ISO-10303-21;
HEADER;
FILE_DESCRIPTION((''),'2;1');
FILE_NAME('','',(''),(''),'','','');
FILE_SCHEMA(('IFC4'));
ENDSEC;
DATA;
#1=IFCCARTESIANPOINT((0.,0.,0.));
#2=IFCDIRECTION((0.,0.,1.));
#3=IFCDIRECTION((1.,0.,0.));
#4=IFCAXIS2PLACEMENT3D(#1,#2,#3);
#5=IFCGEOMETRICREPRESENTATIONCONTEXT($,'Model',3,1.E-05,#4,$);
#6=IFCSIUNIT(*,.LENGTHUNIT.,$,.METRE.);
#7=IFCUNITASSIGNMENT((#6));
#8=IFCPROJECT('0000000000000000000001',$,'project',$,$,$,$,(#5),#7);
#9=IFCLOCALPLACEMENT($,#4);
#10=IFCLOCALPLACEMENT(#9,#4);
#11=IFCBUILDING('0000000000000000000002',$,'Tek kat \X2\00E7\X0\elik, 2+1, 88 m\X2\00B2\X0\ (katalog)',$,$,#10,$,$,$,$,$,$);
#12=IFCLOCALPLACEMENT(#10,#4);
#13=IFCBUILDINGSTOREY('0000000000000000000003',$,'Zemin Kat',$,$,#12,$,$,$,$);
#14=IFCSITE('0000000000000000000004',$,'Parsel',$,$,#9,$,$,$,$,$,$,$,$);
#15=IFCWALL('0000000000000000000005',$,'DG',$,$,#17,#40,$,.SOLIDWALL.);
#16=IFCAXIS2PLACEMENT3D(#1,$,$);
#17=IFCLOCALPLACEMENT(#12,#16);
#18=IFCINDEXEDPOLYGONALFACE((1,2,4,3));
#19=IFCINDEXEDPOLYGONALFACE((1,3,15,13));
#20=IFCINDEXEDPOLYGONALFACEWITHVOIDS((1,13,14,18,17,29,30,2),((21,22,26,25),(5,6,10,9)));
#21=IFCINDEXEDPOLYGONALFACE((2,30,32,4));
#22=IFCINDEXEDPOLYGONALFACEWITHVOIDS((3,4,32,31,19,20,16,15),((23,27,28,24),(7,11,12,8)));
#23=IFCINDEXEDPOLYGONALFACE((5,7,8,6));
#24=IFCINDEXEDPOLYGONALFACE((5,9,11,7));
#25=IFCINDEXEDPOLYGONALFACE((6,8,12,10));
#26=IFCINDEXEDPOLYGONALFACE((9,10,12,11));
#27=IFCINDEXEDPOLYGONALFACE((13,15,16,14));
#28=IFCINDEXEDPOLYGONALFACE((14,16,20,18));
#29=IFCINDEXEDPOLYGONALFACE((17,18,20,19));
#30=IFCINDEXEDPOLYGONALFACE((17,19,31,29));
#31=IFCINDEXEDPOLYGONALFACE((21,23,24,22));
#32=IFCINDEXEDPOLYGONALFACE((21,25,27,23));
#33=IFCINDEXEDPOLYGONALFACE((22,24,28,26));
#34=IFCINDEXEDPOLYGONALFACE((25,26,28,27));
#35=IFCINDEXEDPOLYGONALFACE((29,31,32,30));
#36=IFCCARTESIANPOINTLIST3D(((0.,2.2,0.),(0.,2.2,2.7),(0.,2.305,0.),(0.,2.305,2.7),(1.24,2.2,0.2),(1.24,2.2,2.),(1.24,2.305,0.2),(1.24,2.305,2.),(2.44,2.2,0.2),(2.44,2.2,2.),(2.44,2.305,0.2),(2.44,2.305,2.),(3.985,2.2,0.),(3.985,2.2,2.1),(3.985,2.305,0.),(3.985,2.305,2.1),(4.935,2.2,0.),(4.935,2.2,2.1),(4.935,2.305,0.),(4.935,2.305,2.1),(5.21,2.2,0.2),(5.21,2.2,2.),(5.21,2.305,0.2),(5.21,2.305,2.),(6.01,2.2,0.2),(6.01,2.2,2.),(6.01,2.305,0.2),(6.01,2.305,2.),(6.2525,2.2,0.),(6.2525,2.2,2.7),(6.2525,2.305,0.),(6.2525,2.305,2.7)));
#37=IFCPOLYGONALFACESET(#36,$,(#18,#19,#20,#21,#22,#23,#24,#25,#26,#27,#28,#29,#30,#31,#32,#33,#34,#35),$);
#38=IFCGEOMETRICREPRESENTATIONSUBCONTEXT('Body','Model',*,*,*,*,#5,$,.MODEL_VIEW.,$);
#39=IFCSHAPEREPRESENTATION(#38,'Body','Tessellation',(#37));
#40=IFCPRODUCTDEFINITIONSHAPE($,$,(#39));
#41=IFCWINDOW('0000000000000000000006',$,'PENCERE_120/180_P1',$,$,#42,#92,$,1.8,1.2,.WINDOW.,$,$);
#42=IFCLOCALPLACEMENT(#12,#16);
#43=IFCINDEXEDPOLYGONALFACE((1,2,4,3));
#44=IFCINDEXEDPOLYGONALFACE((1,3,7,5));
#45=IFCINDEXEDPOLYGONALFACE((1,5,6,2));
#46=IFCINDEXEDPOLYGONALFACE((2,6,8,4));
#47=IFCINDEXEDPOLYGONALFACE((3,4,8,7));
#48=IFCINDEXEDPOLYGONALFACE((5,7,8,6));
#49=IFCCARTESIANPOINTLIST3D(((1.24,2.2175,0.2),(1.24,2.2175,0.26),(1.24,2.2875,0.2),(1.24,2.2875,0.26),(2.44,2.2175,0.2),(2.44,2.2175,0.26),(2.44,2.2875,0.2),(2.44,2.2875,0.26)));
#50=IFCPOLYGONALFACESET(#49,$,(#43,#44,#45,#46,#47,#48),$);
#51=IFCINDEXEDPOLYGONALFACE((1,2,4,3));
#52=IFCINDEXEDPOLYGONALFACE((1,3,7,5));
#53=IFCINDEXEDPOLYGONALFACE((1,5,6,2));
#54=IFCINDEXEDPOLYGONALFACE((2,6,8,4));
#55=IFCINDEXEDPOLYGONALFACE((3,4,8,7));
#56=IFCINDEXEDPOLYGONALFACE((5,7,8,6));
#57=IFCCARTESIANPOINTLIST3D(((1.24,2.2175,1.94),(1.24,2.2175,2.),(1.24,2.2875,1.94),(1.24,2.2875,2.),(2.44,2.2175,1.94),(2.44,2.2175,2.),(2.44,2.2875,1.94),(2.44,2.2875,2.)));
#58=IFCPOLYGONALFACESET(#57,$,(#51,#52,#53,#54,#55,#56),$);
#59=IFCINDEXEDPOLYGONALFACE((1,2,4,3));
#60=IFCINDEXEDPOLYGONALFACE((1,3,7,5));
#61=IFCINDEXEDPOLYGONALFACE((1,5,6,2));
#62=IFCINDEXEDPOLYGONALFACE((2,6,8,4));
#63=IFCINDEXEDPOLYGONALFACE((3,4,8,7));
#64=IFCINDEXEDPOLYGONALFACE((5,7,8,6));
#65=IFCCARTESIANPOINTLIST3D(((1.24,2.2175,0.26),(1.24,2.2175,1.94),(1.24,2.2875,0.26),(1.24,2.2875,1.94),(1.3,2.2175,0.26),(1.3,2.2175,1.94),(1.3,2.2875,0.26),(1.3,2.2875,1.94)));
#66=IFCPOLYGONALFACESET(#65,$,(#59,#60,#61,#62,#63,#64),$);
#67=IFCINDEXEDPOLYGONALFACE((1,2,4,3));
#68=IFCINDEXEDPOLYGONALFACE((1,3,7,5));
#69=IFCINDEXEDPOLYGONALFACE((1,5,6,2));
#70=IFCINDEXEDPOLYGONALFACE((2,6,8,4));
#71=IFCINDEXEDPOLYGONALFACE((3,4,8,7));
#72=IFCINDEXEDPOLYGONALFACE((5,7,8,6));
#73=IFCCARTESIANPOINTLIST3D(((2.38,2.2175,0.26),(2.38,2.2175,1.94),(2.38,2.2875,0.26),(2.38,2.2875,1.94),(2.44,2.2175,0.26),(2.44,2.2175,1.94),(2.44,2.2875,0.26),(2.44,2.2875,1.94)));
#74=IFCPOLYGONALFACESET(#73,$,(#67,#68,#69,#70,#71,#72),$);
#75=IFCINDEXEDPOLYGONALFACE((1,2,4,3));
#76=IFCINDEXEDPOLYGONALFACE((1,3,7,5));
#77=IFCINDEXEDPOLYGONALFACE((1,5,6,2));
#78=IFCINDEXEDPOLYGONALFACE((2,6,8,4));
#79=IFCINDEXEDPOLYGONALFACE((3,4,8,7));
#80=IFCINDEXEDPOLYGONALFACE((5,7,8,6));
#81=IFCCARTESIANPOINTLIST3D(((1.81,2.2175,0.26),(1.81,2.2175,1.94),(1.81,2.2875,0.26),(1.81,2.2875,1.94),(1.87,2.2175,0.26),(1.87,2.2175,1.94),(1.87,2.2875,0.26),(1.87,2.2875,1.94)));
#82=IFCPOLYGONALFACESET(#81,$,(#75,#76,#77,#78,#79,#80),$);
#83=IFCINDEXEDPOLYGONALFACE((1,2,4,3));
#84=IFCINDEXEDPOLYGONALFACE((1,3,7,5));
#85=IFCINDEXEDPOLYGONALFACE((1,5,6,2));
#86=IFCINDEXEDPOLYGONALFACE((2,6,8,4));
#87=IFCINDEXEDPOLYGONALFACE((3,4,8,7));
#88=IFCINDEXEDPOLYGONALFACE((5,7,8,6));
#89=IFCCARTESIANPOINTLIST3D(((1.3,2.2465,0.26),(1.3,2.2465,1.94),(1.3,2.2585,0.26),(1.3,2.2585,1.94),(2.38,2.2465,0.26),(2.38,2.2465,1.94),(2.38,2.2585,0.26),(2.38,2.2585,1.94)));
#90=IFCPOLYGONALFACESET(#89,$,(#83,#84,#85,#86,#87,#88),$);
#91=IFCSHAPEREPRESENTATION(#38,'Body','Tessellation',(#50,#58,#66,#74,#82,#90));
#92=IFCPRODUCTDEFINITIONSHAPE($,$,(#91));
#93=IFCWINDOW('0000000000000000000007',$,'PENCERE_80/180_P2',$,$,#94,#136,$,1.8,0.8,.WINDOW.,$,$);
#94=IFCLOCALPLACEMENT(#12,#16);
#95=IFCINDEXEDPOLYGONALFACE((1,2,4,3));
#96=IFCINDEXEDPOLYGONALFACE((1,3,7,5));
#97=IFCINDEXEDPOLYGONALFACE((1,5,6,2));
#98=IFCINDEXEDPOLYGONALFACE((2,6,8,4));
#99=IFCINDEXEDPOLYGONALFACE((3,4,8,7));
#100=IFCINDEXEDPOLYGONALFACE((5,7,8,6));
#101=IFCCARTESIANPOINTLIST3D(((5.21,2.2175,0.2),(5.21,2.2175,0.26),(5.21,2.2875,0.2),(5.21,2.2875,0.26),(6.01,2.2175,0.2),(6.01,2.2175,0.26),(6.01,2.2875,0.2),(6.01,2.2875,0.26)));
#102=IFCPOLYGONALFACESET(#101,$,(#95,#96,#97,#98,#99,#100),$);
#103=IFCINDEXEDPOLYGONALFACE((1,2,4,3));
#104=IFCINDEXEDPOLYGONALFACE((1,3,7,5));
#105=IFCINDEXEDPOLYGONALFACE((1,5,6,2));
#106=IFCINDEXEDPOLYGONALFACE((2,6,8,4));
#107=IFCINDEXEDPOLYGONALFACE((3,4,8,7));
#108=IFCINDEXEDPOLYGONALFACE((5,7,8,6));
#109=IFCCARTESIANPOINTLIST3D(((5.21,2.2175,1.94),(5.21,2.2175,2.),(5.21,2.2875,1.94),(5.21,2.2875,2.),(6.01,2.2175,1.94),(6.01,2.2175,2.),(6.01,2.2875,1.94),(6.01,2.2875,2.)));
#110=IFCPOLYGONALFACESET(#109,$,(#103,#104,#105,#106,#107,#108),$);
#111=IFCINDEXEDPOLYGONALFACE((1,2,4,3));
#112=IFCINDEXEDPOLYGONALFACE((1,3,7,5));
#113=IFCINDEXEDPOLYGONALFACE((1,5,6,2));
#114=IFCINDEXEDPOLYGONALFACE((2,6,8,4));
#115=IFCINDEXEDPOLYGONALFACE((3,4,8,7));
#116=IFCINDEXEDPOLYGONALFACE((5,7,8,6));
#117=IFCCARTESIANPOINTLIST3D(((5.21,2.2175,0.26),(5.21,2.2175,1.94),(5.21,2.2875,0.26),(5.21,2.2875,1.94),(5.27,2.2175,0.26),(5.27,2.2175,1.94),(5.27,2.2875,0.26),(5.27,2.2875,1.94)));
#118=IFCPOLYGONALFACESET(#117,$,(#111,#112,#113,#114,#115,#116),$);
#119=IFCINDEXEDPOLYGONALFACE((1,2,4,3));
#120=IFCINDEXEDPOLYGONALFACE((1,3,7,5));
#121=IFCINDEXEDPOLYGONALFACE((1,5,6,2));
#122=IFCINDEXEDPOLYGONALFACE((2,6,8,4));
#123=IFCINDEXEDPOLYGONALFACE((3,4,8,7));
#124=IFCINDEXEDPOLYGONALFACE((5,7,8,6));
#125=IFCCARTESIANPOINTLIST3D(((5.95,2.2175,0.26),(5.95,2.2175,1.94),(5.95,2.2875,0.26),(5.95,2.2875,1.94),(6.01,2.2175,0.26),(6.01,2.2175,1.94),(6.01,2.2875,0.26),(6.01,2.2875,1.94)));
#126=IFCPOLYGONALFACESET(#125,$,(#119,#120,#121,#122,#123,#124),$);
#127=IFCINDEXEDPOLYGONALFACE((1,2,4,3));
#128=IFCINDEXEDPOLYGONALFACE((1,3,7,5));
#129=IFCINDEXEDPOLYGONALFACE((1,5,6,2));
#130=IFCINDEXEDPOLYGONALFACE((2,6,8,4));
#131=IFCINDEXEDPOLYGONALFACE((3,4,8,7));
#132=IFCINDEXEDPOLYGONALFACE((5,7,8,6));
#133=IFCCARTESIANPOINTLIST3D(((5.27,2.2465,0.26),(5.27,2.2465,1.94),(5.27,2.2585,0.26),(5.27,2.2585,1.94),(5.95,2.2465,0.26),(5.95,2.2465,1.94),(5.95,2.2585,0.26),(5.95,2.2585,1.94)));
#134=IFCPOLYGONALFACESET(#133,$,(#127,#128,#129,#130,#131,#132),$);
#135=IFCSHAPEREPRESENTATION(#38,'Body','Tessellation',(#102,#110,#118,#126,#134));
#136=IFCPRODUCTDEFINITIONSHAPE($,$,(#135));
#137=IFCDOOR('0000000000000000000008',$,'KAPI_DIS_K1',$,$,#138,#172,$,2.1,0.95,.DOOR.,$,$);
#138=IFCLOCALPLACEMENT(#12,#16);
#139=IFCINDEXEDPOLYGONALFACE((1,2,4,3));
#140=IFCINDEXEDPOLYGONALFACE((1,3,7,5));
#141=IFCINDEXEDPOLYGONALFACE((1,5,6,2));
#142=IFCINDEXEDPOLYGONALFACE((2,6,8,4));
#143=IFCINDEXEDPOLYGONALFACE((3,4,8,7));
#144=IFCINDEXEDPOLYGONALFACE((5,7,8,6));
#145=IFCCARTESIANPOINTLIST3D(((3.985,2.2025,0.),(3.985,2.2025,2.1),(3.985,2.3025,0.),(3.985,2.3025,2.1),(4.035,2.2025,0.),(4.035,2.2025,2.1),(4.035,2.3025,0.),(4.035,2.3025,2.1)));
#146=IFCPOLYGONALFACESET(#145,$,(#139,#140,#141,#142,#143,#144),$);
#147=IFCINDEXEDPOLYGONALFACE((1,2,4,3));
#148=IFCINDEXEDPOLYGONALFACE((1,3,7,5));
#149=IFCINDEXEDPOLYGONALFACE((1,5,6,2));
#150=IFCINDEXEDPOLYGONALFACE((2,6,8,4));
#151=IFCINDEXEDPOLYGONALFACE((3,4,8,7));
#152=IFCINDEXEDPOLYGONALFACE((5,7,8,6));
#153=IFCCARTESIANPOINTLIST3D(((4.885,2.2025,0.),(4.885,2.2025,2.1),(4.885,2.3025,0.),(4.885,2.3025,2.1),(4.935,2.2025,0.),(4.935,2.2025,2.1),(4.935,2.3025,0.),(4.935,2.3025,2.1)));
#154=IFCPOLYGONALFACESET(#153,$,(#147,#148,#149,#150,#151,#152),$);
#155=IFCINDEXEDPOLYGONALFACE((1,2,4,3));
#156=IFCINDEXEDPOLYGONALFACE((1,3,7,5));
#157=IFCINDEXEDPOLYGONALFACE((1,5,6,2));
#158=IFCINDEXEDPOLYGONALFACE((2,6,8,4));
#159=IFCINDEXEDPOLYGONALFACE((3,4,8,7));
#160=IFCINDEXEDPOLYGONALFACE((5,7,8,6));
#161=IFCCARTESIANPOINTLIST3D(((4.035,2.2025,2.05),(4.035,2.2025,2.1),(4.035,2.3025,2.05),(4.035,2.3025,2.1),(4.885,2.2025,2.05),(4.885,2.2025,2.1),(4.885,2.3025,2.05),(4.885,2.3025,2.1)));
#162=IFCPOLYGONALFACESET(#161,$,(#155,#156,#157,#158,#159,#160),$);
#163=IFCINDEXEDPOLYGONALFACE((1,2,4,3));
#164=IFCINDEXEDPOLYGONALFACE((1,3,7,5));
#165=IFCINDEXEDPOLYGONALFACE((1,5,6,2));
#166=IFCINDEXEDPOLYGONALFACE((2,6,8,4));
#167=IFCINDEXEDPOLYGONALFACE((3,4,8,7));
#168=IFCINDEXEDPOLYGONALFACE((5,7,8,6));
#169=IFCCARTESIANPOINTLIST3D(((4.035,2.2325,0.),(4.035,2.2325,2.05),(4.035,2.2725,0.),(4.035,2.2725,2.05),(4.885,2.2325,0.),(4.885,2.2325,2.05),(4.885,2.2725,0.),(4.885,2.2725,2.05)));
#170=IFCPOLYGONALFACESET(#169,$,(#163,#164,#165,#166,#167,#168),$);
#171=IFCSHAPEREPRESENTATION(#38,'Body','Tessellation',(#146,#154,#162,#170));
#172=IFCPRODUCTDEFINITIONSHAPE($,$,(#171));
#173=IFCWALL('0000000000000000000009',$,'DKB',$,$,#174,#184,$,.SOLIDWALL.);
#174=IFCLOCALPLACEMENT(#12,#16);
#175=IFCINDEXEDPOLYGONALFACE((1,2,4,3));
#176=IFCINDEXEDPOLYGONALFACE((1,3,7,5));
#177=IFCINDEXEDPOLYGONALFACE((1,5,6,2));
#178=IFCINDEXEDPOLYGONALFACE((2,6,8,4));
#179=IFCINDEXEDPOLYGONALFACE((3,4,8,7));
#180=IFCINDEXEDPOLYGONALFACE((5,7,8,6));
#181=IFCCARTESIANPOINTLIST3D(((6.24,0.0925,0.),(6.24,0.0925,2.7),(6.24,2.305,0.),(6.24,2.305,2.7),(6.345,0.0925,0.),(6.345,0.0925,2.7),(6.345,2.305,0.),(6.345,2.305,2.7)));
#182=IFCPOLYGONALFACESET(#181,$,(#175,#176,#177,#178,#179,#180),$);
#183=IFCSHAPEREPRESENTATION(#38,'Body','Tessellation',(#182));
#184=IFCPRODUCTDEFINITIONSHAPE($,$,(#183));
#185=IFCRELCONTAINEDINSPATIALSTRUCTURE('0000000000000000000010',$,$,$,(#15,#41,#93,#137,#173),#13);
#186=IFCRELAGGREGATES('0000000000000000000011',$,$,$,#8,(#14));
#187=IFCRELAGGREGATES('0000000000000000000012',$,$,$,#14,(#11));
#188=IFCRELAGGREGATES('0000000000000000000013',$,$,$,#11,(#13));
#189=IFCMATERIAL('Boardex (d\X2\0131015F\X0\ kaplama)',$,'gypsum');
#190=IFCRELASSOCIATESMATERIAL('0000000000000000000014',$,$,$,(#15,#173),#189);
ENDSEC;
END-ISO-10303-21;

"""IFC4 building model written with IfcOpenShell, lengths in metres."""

from ifc_helpers import new_model, si_unit, frame, origin_with_axes, place, context, subcontext, project, spatial, line, indexed_curve, outline, extrude, material, element, fill, save


model = new_model("IFC4")

# Units and contexts
model_context = context("Model", 3, precision=1e-05, world=origin_with_axes())
body_context = subcontext(model_context, "Body", "Model", "MODEL_VIEW")
ifc_project = project(units=[si_unit("LENGTHUNIT", "METRE")], contexts=[model_context])

# Site, building, storey
site_placement = place(None, origin_with_axes())
site = spatial("IfcSite", under=ifc_project, at=site_placement, Name="Parsel")
building_placement = place(site_placement, origin_with_axes())
building = spatial("IfcBuilding", under=site, at=building_placement, Name="Tek kat çelik, 2+1, 88 m² (katalog)")
storey_placement = place(building_placement, origin_with_axes())
storey = spatial("IfcBuildingStorey", under=building, at=storey_placement, Name="Zemin Kat")

# Shared definitions
ifc_material = material(Name="Boardex (dış kaplama)", Category="gypsum")

# Wall, openings, windows, door
wall_1_placement = place(storey_placement, origin_with_axes())
wall_1 = element("IfcWall", 1, at=wall_1_placement, inside=storey, material=ifc_material, Name="DG", PredefinedType="SOLIDWALL", context=body_context, shape_type="SweptSolid", body=[
    extrude(outline(indexed_curve([(0.0, 0.0), (6.2525, 0.0), (6.2525, 0.105), (0.0, 0.105)], segments=[line(1, 2, 3, 4, 1)])), frame((0.0, 2.2, 0.0), z_axis=(0.0, 0.0, 1.0), x_axis=(1.0, 0.0, 0.0)), (0.0, 0.0, 1.0), 2.7),
])
opening_1_placement = place(wall_1_placement, origin_with_axes())
opening_1 = element("IfcOpeningElement", 2, at=opening_1_placement, cuts=wall_1, PredefinedType="OPENING", context=body_context, shape_type="SweptSolid", body=[
    extrude(outline(indexed_curve([(0.0, 0.0), (1.2, 0.0), (1.2, 0.145), (0.0, 0.145)], segments=[line(1, 2, 3, 4, 1)])), frame((1.24, 2.18, 0.2), z_axis=(0.0, 0.0, 1.0), x_axis=(1.0, 0.0, 0.0)), (0.0, 0.0, 1.0), 1.8),
])
opening_2_placement = place(wall_1_placement, origin_with_axes())
opening_2 = element("IfcOpeningElement", 3, at=opening_2_placement, cuts=wall_1, PredefinedType="OPENING", context=body_context, shape_type="SweptSolid", body=[
    extrude(outline(indexed_curve([(0.0, 0.0), (0.8, 0.0), (0.8, 0.145), (0.0, 0.145)], segments=[line(1, 2, 3, 4, 1)])), frame((5.21, 2.18, 0.2), z_axis=(0.0, 0.0, 1.0), x_axis=(1.0, 0.0, 0.0)), (0.0, 0.0, 1.0), 1.8),
])
opening_3_placement = place(wall_1_placement, origin_with_axes())
opening_3 = element("IfcOpeningElement", 4, at=opening_3_placement, cuts=wall_1, PredefinedType="OPENING", context=body_context, shape_type="SweptSolid", body=[
    extrude(outline(indexed_curve([(0.0, 0.0), (0.95, 0.0), (0.95, 0.145), (0.0, 0.145)], segments=[line(1, 2, 3, 4, 1)])), frame((3.985, 2.18, 0.0), z_axis=(0.0, 0.0, 1.0), x_axis=(1.0, 0.0, 0.0)), (0.0, 0.0, 1.0), 2.1),
])
window_1_placement = place(storey_placement, origin_with_axes())
window_1 = element("IfcWindow", 5, at=window_1_placement, inside=storey, Name="PENCERE_120/180_P1", OverallHeight=1.8, OverallWidth=1.2, PredefinedType="WINDOW", context=body_context, shape_type="SweptSolid", body=[
    extrude(outline(indexed_curve([(0.0, 0.0), (1.2, 0.0), (1.2, 0.07), (0.0, 0.07)], segments=[line(1, 2, 3, 4, 1)])), frame((1.24, 2.2175, 0.2), z_axis=(0.0, 0.0, 1.0), x_axis=(1.0, 0.0, 0.0)), (0.0, 0.0, 1.0), 0.06),
    extrude(outline(indexed_curve([(0.0, 0.0), (1.2, 0.0), (1.2, 0.07), (0.0, 0.07)], segments=[line(1, 2, 3, 4, 1)])), frame((1.24, 2.2175, 1.94), z_axis=(0.0, 0.0, 1.0), x_axis=(1.0, 0.0, 0.0)), (0.0, 0.0, 1.0), 0.06),
    extrude(outline(indexed_curve([(0.0, 0.0), (0.06, 0.0), (0.06, 0.07), (0.0, 0.07)], segments=[line(1, 2, 3, 4, 1)])), frame((1.24, 2.2175, 0.26), z_axis=(0.0, 0.0, 1.0), x_axis=(1.0, 0.0, 0.0)), (0.0, 0.0, 1.0), 1.68),
    extrude(outline(indexed_curve([(0.0, 0.0), (0.06, 0.0), (0.06, 0.07), (0.0, 0.07)], segments=[line(1, 2, 3, 4, 1)])), frame((2.38, 2.2175, 0.26), z_axis=(0.0, 0.0, 1.0), x_axis=(1.0, 0.0, 0.0)), (0.0, 0.0, 1.0), 1.68),
    extrude(outline(indexed_curve([(0.0, 0.0), (0.06, 0.0), (0.06, 0.07), (0.0, 0.07)], segments=[line(1, 2, 3, 4, 1)])), frame((1.81, 2.2175, 0.26), z_axis=(0.0, 0.0, 1.0), x_axis=(1.0, 0.0, 0.0)), (0.0, 0.0, 1.0), 1.68),
    extrude(outline(indexed_curve([(0.0, 0.0), (1.08, 0.0), (1.08, 0.012), (0.0, 0.012)], segments=[line(1, 2, 3, 4, 1)])), frame((1.3, 2.2465, 0.26), z_axis=(0.0, 0.0, 1.0), x_axis=(1.0, 0.0, 0.0)), (0.0, 0.0, 1.0), 1.68),
])
fill(opening_1, window_1)
window_2_placement = place(storey_placement, origin_with_axes())
window_2 = element("IfcWindow", 6, at=window_2_placement, inside=storey, Name="PENCERE_80/180_P2", OverallHeight=1.8, OverallWidth=0.8, PredefinedType="WINDOW", context=body_context, shape_type="SweptSolid", body=[
    extrude(outline(indexed_curve([(0.0, 0.0), (0.8, 0.0), (0.8, 0.07), (0.0, 0.07)], segments=[line(1, 2, 3, 4, 1)])), frame((5.21, 2.2175, 0.2), z_axis=(0.0, 0.0, 1.0), x_axis=(1.0, 0.0, 0.0)), (0.0, 0.0, 1.0), 0.06),
    extrude(outline(indexed_curve([(0.0, 0.0), (0.8, 0.0), (0.8, 0.07), (0.0, 0.07)], segments=[line(1, 2, 3, 4, 1)])), frame((5.21, 2.2175, 1.94), z_axis=(0.0, 0.0, 1.0), x_axis=(1.0, 0.0, 0.0)), (0.0, 0.0, 1.0), 0.06),
    extrude(outline(indexed_curve([(0.0, 0.0), (0.06, 0.0), (0.06, 0.07), (0.0, 0.07)], segments=[line(1, 2, 3, 4, 1)])), frame((5.21, 2.2175, 0.26), z_axis=(0.0, 0.0, 1.0), x_axis=(1.0, 0.0, 0.0)), (0.0, 0.0, 1.0), 1.68),
    extrude(outline(indexed_curve([(0.0, 0.0), (0.06, 0.0), (0.06, 0.07), (0.0, 0.07)], segments=[line(1, 2, 3, 4, 1)])), frame((5.95, 2.2175, 0.26), z_axis=(0.0, 0.0, 1.0), x_axis=(1.0, 0.0, 0.0)), (0.0, 0.0, 1.0), 1.68),
    extrude(outline(indexed_curve([(0.0, 0.0), (0.68, 0.0), (0.68, 0.012), (0.0, 0.012)], segments=[line(1, 2, 3, 4, 1)])), frame((5.27, 2.2465, 0.26), z_axis=(0.0, 0.0, 1.0), x_axis=(1.0, 0.0, 0.0)), (0.0, 0.0, 1.0), 1.68),
])
fill(opening_2, window_2)
door_placement = place(storey_placement, origin_with_axes())
door = element("IfcDoor", 7, at=door_placement, inside=storey, Name="KAPI_DIS_K1", OverallHeight=2.1, OverallWidth=0.95, PredefinedType="DOOR", context=body_context, shape_type="SweptSolid", body=[
    extrude(outline(indexed_curve([(0.0, 0.0), (0.05, 0.0), (0.05, 0.1), (0.0, 0.1)], segments=[line(1, 2, 3, 4, 1)])), frame((3.985, 2.2025, 0.0), z_axis=(0.0, 0.0, 1.0), x_axis=(1.0, 0.0, 0.0)), (0.0, 0.0, 1.0), 2.1),
    extrude(outline(indexed_curve([(0.0, 0.0), (0.05, 0.0), (0.05, 0.1), (0.0, 0.1)], segments=[line(1, 2, 3, 4, 1)])), frame((4.885, 2.2025, 0.0), z_axis=(0.0, 0.0, 1.0), x_axis=(1.0, 0.0, 0.0)), (0.0, 0.0, 1.0), 2.1),
    extrude(outline(indexed_curve([(0.0, 0.0), (0.85, 0.0), (0.85, 0.1), (0.0, 0.1)], segments=[line(1, 2, 3, 4, 1)])), frame((4.035, 2.2025, 2.05), z_axis=(0.0, 0.0, 1.0), x_axis=(1.0, 0.0, 0.0)), (0.0, 0.0, 1.0), 0.05),
    extrude(outline(indexed_curve([(0.0, 0.0), (0.85, 0.0), (0.85, 0.04), (0.0, 0.04)], segments=[line(1, 2, 3, 4, 1)])), frame((4.035, 2.2325, 0.0), z_axis=(0.0, 0.0, 1.0), x_axis=(1.0, 0.0, 0.0)), (0.0, 0.0, 1.0), 2.05),
])
fill(opening_3, door)

# Wall
wall_2_placement = place(storey_placement, origin_with_axes())
element("IfcWall", 8, at=wall_2_placement, inside=storey, material=ifc_material, Name="DKB", PredefinedType="SOLIDWALL", context=body_context, shape_type="SweptSolid", body=[
    extrude(outline(indexed_curve([(0.0, 0.0), (0.105, 0.0), (0.105, 2.2125), (0.0, 2.2125)], segments=[line(1, 2, 3, 4, 1)])), frame((6.24, 0.0925, 0.0), z_axis=(0.0, 0.0, 1.0), x_axis=(1.0, 0.0, 0.0)), (0.0, 0.0, 1.0), 2.7),
])

save(model, "model.ifc")
